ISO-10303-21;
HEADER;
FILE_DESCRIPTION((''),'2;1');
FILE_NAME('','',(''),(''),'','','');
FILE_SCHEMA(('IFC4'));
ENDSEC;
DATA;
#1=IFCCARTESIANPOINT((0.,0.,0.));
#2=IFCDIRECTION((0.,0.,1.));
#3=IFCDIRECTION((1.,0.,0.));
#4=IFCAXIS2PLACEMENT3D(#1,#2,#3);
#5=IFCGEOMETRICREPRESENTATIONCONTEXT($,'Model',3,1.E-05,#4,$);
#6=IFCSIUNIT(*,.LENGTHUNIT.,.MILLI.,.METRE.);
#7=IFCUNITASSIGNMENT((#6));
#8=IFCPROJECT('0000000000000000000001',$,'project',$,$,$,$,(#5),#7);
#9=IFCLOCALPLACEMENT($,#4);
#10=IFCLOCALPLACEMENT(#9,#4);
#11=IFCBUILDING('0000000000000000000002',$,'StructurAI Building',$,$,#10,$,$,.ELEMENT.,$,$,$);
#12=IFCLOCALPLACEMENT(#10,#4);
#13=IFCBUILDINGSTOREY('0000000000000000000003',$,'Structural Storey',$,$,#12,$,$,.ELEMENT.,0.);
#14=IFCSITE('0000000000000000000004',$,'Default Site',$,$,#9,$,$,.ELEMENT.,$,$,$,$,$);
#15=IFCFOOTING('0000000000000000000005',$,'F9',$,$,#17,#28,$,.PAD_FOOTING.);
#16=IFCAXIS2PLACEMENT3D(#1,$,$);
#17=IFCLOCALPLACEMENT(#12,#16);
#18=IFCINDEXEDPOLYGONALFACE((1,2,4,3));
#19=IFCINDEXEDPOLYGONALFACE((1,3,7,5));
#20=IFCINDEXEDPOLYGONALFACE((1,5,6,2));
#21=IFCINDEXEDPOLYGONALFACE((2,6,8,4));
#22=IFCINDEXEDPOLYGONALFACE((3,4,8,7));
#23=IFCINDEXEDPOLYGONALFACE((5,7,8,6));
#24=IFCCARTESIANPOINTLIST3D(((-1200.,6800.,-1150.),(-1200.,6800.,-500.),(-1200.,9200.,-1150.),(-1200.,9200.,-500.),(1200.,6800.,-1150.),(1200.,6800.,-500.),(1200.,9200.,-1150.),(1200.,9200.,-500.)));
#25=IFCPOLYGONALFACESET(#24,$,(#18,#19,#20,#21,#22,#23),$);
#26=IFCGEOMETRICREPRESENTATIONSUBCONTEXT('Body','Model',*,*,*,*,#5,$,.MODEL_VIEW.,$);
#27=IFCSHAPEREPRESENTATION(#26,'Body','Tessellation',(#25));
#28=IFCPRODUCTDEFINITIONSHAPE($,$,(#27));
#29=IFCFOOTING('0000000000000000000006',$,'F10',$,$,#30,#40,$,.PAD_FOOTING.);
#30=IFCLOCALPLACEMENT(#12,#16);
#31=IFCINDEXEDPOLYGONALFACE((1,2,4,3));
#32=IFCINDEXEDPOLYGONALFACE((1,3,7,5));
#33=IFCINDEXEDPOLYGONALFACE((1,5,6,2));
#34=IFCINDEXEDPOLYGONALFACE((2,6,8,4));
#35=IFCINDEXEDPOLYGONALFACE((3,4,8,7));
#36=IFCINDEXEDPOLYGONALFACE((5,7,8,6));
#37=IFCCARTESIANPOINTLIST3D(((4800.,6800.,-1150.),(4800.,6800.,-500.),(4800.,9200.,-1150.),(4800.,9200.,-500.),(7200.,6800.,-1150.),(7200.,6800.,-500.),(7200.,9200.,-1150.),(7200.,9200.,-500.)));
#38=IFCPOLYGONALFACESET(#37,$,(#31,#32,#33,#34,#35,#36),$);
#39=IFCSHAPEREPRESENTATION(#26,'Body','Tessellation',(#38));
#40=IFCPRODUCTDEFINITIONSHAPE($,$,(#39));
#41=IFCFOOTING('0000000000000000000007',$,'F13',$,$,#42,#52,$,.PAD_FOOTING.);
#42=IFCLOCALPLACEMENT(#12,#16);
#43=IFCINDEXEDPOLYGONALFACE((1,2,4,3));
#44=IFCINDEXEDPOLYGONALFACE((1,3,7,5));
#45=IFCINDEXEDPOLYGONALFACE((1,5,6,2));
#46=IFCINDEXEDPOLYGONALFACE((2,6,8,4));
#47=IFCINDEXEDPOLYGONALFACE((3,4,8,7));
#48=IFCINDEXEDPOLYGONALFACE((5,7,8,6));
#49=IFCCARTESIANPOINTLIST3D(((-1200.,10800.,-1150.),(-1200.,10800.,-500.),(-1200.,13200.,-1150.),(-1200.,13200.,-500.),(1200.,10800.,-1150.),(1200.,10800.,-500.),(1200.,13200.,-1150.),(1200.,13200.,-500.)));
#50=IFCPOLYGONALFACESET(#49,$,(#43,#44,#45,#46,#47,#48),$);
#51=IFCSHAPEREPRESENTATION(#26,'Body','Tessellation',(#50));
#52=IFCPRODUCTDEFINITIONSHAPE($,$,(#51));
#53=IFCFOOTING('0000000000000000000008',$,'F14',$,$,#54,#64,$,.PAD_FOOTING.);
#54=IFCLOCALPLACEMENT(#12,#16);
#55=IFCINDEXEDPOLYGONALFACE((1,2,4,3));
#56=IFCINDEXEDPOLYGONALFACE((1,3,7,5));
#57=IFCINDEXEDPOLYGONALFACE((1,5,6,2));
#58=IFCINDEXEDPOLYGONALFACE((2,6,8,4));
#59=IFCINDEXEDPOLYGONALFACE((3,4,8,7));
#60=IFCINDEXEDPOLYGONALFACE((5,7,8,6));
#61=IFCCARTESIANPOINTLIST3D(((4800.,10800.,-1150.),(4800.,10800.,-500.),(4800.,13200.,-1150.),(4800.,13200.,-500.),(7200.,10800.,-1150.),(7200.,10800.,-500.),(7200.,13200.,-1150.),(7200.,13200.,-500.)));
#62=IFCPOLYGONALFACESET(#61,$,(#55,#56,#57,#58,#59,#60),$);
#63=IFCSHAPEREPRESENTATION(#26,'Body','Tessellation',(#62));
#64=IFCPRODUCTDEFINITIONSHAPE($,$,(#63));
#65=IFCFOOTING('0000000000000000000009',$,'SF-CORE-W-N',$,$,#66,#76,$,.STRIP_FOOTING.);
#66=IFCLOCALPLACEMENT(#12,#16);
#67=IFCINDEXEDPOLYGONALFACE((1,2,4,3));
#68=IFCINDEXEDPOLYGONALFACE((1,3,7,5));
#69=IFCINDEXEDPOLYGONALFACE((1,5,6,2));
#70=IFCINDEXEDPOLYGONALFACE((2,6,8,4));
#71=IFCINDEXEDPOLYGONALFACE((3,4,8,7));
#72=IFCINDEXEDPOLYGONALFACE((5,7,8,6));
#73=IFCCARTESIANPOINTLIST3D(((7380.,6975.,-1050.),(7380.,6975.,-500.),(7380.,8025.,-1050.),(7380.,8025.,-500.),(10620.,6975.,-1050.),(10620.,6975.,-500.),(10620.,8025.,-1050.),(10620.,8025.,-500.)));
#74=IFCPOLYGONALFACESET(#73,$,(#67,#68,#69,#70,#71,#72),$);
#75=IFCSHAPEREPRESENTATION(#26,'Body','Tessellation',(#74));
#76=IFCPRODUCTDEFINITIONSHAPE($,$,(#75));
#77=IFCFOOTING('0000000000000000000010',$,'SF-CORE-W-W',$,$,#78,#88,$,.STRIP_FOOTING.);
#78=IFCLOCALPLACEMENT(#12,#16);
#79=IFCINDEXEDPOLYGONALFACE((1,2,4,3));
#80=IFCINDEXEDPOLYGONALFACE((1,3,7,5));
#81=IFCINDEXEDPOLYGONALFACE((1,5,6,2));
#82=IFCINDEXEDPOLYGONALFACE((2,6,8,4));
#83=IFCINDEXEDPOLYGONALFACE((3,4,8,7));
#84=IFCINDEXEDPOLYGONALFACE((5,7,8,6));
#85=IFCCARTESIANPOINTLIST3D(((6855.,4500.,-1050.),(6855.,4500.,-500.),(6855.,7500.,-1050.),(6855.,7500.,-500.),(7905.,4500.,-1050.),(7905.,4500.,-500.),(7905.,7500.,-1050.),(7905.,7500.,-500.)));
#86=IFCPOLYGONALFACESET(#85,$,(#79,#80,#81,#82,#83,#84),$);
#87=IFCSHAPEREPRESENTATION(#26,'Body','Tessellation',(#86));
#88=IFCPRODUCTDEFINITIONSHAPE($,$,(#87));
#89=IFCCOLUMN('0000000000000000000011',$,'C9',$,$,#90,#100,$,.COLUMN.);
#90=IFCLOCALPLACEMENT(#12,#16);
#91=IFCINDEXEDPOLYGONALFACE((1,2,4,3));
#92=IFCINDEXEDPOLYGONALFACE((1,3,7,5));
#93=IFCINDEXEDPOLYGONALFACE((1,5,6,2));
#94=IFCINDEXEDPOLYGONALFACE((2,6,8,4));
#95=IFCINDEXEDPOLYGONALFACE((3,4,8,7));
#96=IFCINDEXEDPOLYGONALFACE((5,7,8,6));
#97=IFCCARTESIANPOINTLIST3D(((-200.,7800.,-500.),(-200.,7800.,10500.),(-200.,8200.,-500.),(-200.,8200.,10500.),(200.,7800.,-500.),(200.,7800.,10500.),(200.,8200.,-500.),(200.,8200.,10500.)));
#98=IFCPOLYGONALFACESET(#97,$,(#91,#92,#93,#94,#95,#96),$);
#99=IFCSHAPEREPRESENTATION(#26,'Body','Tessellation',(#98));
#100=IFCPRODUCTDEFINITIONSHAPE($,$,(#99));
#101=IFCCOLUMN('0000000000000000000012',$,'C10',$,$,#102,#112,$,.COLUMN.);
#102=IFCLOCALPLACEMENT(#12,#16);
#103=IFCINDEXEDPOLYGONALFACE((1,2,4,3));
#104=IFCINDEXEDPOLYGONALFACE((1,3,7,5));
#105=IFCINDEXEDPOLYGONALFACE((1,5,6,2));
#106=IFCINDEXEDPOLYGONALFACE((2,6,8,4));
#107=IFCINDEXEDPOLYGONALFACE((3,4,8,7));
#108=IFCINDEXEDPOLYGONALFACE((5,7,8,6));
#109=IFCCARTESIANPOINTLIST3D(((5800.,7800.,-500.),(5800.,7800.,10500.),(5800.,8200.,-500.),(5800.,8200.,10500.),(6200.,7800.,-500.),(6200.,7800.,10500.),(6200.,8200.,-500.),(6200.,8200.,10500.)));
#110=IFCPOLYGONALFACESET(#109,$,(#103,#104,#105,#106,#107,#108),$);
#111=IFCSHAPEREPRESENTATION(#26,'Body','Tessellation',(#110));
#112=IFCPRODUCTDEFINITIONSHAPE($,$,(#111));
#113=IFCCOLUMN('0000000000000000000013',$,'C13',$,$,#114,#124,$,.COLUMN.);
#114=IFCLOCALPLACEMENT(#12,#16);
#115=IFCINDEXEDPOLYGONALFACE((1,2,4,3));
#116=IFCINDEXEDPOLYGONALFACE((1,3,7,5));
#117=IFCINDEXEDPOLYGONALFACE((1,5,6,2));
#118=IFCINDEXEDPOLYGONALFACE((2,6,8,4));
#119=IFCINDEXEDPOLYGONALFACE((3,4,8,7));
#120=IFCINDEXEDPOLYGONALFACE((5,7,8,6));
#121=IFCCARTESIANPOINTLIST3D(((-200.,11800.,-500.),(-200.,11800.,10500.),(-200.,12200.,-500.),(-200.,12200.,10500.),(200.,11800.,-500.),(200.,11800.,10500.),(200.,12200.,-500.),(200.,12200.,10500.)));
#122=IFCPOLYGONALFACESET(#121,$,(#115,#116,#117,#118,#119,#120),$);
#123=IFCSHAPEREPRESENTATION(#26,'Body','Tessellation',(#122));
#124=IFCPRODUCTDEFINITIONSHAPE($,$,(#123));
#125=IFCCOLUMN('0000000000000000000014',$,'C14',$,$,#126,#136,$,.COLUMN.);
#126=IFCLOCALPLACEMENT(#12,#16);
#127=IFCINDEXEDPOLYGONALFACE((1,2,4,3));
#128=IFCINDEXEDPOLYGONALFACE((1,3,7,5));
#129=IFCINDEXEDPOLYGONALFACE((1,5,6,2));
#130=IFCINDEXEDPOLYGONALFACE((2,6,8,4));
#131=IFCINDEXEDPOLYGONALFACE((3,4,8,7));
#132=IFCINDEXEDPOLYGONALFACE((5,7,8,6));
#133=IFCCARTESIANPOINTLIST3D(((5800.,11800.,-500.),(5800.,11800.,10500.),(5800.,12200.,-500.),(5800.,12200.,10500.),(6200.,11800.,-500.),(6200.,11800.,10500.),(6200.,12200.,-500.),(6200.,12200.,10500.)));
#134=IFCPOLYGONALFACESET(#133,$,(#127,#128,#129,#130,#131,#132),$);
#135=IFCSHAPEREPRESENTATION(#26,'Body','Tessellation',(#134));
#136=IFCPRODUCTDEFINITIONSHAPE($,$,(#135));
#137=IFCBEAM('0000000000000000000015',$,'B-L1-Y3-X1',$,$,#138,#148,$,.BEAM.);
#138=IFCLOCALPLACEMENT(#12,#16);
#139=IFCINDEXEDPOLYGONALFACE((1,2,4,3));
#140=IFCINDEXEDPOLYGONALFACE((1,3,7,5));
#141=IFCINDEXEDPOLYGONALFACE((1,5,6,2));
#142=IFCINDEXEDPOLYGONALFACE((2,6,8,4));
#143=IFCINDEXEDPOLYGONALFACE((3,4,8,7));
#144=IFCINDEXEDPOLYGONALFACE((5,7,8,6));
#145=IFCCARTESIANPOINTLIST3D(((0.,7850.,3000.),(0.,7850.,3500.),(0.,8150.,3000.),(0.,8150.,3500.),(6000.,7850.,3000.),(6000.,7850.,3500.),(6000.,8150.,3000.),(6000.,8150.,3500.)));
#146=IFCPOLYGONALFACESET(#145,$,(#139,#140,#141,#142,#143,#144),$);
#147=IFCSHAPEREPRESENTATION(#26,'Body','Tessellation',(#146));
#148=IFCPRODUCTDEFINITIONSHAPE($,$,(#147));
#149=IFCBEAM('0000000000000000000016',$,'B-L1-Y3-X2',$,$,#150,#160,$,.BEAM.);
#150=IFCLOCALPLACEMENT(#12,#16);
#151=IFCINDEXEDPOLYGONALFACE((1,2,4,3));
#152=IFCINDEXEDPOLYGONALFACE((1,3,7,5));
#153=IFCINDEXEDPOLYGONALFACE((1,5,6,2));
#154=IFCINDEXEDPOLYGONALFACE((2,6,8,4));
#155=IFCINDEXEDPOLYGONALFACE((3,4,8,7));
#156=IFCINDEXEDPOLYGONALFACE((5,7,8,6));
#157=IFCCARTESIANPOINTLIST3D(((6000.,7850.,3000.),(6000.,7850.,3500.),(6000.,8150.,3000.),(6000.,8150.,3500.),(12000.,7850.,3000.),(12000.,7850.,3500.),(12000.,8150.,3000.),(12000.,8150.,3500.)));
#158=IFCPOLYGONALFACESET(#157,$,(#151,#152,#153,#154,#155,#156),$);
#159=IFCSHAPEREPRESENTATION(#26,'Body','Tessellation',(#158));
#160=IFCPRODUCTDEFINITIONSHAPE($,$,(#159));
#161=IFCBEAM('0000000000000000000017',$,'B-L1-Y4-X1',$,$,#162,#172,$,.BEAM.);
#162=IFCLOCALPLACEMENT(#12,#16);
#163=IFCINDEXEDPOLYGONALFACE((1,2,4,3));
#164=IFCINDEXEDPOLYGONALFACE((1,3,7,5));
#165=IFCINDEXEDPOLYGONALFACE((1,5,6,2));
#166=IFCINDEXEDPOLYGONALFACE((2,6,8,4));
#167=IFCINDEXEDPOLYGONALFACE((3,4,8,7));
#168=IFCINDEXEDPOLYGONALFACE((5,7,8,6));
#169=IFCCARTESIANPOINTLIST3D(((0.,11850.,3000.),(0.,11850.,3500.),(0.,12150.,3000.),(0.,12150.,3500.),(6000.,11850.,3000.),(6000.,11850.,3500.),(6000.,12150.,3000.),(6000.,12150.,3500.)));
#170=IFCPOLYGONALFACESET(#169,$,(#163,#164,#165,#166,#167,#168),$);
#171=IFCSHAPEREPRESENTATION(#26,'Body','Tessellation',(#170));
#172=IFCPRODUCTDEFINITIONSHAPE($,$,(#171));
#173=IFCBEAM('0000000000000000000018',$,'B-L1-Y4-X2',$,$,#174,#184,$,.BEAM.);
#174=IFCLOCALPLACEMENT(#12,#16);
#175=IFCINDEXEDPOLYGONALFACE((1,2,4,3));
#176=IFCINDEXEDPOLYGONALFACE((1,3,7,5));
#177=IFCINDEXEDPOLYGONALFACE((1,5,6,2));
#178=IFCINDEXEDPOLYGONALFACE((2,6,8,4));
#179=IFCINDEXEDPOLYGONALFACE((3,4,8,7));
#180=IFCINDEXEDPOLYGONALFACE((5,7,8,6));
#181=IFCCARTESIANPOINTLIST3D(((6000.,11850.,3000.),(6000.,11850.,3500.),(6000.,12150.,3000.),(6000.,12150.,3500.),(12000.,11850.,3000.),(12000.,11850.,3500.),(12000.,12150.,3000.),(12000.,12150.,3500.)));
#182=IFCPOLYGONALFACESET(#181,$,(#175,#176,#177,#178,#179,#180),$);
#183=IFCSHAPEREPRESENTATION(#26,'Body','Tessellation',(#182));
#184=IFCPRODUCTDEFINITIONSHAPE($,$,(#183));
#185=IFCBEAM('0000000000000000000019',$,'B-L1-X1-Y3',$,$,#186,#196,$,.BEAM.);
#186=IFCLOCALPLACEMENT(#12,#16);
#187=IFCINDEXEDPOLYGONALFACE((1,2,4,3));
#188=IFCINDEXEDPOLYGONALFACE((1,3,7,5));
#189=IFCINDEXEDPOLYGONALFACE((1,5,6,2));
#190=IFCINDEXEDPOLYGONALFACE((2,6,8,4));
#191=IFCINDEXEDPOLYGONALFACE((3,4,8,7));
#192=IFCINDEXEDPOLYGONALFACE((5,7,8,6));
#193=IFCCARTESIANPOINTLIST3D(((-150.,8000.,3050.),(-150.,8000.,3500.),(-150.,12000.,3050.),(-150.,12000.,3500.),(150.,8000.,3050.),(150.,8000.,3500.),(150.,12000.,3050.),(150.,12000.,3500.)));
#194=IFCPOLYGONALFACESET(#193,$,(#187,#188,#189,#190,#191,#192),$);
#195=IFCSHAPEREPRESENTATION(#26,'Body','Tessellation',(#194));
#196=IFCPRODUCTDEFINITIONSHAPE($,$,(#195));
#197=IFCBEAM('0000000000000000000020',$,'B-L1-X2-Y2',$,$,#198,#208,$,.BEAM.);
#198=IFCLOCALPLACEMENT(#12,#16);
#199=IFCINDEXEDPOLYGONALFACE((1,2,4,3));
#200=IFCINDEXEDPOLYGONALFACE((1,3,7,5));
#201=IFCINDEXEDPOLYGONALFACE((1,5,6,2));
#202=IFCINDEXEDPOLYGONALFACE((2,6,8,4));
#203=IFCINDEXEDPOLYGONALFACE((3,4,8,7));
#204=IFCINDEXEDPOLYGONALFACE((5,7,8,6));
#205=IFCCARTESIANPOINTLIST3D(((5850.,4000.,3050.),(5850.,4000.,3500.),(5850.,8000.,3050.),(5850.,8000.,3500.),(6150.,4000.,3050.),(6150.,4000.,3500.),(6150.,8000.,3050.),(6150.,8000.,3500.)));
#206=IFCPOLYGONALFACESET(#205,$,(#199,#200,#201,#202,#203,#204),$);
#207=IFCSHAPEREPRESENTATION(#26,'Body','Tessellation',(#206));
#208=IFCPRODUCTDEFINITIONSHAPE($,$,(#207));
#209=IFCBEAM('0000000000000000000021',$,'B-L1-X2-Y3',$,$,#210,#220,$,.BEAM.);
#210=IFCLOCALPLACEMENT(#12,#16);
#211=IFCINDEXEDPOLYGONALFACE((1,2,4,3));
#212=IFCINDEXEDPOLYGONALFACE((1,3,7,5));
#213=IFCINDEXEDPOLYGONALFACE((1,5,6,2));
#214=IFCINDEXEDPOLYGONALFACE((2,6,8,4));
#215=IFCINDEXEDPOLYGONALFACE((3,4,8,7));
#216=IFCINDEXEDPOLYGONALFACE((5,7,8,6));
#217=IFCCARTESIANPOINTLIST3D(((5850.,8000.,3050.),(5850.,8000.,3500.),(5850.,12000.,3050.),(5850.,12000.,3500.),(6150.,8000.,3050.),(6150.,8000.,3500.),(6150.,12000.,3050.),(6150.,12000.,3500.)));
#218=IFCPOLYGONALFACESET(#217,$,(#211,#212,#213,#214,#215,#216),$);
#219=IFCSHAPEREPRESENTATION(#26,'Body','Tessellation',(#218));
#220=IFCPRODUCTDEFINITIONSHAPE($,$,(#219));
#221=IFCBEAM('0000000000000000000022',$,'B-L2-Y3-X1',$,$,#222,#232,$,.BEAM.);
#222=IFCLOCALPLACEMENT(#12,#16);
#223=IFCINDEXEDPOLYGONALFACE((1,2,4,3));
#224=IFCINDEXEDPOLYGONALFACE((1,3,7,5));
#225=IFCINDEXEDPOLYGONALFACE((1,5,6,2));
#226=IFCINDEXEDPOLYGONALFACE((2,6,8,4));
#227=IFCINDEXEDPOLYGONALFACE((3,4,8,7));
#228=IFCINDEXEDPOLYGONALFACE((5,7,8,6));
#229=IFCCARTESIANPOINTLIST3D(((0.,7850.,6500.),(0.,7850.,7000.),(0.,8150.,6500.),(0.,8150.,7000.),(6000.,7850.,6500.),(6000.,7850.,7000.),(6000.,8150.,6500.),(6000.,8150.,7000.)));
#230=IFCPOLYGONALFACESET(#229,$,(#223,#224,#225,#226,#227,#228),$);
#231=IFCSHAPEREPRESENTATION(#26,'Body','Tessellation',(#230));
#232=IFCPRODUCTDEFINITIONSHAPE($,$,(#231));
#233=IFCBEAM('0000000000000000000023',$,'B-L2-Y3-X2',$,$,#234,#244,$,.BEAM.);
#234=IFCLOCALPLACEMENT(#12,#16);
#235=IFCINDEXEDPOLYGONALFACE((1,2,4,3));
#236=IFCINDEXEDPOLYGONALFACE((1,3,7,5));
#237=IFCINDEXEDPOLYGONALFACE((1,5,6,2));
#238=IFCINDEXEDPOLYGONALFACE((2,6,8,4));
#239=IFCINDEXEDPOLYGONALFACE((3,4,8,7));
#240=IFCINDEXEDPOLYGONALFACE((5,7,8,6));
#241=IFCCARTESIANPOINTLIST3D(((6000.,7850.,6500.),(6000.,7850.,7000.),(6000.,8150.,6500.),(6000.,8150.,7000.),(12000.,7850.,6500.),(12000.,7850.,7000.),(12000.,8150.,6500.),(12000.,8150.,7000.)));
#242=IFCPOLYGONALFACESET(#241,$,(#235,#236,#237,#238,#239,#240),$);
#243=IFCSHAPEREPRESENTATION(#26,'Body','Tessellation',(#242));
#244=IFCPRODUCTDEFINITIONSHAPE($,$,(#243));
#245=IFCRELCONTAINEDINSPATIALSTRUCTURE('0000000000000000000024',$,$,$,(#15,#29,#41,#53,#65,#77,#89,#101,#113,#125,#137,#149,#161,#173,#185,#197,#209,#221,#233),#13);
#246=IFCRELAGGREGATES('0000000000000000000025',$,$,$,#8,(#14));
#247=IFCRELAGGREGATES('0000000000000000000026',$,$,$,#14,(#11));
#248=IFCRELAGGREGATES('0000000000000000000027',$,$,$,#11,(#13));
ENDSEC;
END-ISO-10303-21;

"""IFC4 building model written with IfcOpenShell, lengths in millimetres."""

from ifc_helpers import new_model, si_unit, frame, origin_with_axes, place, context, subcontext, project, spatial, rectangle, extrude, element, save


model = new_model("IFC4")

# Units and contexts
model_context = context("Model", 3, precision=1e-05, world=origin_with_axes())
body_context = subcontext(model_context, "Body", "Model", "MODEL_VIEW")
ifc_project = project(units=[si_unit("LENGTHUNIT", "METRE", prefix="MILLI")], contexts=[model_context])

# Site, building, storey
site_placement = place(None, origin_with_axes())
site = spatial("IfcSite", under=ifc_project, at=site_placement, Name="Default Site", CompositionType="ELEMENT")
building_placement = place(site_placement, origin_with_axes())
building = spatial("IfcBuilding", under=site, at=building_placement, Name="StructurAI Building", CompositionType="ELEMENT")
storey_placement = place(building_placement, origin_with_axes())
storey = spatial("IfcBuildingStorey", under=building, at=storey_placement, Name="Structural Storey", CompositionType="ELEMENT", Elevation=0.0)

# Footings
for number, where, z_axis, x_axis, name in (
    (1, (0.0, 8000.0, -1150.0), (0.0, 0.0, 1.0), (1.0, 0.0, 0.0), "F9"),
    (2, (6000.0, 8000.0, -1150.0), (0.0, 0.0, 1.0), (1.0, 0.0, 0.0), "F10"),
    (3, (0.0, 12000.0, -1150.0), (0.0, 0.0, 1.0), (1.0, 0.0, 0.0), "F13"),
    (4, (6000.0, 12000.0, -1150.0), (0.0, 0.0, 1.0), (1.0, 0.0, 0.0), "F14"),
):
    element("IfcFooting", number, at=place(storey_placement, frame(where, z_axis=z_axis, x_axis=x_axis)), inside=storey, Name=name, PredefinedType="PAD_FOOTING", context=body_context, shape_type="SweptSolid", body=[
        extrude(rectangle(XDim=2400.0, YDim=2400.0), origin_with_axes(), (0.0, 0.0, 1.0), 650.0),
    ])
footing_1_placement = place(storey_placement, frame((9000.0, 7500.0, -1050.0), z_axis=(0.0, 0.0, 1.0), x_axis=(1.0, 0.0, 0.0)))
element("IfcFooting", 5, at=footing_1_placement, inside=storey, Name="SF-CORE-W-N", PredefinedType="STRIP_FOOTING", context=body_context, shape_type="SweptSolid", body=[
    extrude(rectangle(XDim=3240.0, YDim=1050.0), origin_with_axes(), (0.0, 0.0, 1.0), 550.0),
])
footing_2_placement = place(storey_placement, frame((7380.0, 6000.0, -1050.0), z_axis=(0.0, 0.0, 1.0), x_axis=(0.0, 1.0, 0.0)))
element("IfcFooting", 6, at=footing_2_placement, inside=storey, Name="SF-CORE-W-W", PredefinedType="STRIP_FOOTING", context=body_context, shape_type="SweptSolid", body=[
    extrude(rectangle(XDim=3000.0, YDim=1050.0), origin_with_axes(), (0.0, 0.0, 1.0), 550.0),
])

# Columns
for number, where, z_axis, x_axis, name in (
    (7, (0.0, 8000.0, -500.0), (0.0, 0.0, 1.0), (1.0, 0.0, 0.0), "C9"),
    (8, (6000.0, 8000.0, -500.0), (0.0, 0.0, 1.0), (1.0, 0.0, 0.0), "C10"),
    (9, (0.0, 12000.0, -500.0), (0.0, 0.0, 1.0), (1.0, 0.0, 0.0), "C13"),
    (10, (6000.0, 12000.0, -500.0), (0.0, 0.0, 1.0), (1.0, 0.0, 0.0), "C14"),
):
    element("IfcColumn", number, at=place(storey_placement, frame(where, z_axis=z_axis, x_axis=x_axis)), inside=storey, Name=name, PredefinedType="COLUMN", context=body_context, shape_type="SweptSolid", body=[
        extrude(rectangle(XDim=400.0, YDim=400.0), origin_with_axes(), (0.0, 0.0, 1.0), 11000.0),
    ])

# Beams
for number, where, z_axis, x_axis, name in (
    (11, (3000.0, 8000.0, 3000.0), (0.0, 0.0, 1.0), (1.0, 0.0, 0.0), "B-L1-Y3-X1"),
    (12, (9000.0, 8000.0, 3000.0), (0.0, 0.0, 1.0), (1.0, 0.0, 0.0), "B-L1-Y3-X2"),
    (13, (3000.0, 12000.0, 3000.0), (0.0, 0.0, 1.0), (1.0, 0.0, 0.0), "B-L1-Y4-X1"),
    (14, (9000.0, 12000.0, 3000.0), (0.0, 0.0, 1.0), (1.0, 0.0, 0.0), "B-L1-Y4-X2"),
):
    element("IfcBeam", number, at=place(storey_placement, frame(where, z_axis=z_axis, x_axis=x_axis)), inside=storey, Name=name, PredefinedType="BEAM", context=body_context, shape_type="SweptSolid", body=[
        extrude(rectangle(XDim=6000.0, YDim=300.0), origin_with_axes(), (0.0, 0.0, 1.0), 500.0),
    ])
for number, where, z_axis, x_axis, name in (
    (15, (0.0, 10000.0, 3050.0), (0.0, 0.0, 1.0), (0.0, 1.0, 0.0), "B-L1-X1-Y3"),
    (16, (6000.0, 6000.0, 3050.0), (0.0, 0.0, 1.0), (0.0, 1.0, 0.0), "B-L1-X2-Y2"),
    (17, (6000.0, 10000.0, 3050.0), (0.0, 0.0, 1.0), (0.0, 1.0, 0.0), "B-L1-X2-Y3"),
):
    element("IfcBeam", number, at=place(storey_placement, frame(where, z_axis=z_axis, x_axis=x_axis)), inside=storey, Name=name, PredefinedType="BEAM", context=body_context, shape_type="SweptSolid", body=[
        extrude(rectangle(XDim=4000.0, YDim=300.0), origin_with_axes(), (0.0, 0.0, 1.0), 450.0),
    ])
for number, where, z_axis, x_axis, name in (
    (18, (3000.0, 8000.0, 6500.0), (0.0, 0.0, 1.0), (1.0, 0.0, 0.0), "B-L2-Y3-X1"),
    (19, (9000.0, 8000.0, 6500.0), (0.0, 0.0, 1.0), (1.0, 0.0, 0.0), "B-L2-Y3-X2"),
):
    element("IfcBeam", number, at=place(storey_placement, frame(where, z_axis=z_axis, x_axis=x_axis)), inside=storey, Name=name, PredefinedType="BEAM", context=body_context, shape_type="SweptSolid", body=[
        extrude(rectangle(XDim=6000.0, YDim=300.0), origin_with_axes(), (0.0, 0.0, 1.0), 500.0),
    ])

save(model, "model.ifc")
